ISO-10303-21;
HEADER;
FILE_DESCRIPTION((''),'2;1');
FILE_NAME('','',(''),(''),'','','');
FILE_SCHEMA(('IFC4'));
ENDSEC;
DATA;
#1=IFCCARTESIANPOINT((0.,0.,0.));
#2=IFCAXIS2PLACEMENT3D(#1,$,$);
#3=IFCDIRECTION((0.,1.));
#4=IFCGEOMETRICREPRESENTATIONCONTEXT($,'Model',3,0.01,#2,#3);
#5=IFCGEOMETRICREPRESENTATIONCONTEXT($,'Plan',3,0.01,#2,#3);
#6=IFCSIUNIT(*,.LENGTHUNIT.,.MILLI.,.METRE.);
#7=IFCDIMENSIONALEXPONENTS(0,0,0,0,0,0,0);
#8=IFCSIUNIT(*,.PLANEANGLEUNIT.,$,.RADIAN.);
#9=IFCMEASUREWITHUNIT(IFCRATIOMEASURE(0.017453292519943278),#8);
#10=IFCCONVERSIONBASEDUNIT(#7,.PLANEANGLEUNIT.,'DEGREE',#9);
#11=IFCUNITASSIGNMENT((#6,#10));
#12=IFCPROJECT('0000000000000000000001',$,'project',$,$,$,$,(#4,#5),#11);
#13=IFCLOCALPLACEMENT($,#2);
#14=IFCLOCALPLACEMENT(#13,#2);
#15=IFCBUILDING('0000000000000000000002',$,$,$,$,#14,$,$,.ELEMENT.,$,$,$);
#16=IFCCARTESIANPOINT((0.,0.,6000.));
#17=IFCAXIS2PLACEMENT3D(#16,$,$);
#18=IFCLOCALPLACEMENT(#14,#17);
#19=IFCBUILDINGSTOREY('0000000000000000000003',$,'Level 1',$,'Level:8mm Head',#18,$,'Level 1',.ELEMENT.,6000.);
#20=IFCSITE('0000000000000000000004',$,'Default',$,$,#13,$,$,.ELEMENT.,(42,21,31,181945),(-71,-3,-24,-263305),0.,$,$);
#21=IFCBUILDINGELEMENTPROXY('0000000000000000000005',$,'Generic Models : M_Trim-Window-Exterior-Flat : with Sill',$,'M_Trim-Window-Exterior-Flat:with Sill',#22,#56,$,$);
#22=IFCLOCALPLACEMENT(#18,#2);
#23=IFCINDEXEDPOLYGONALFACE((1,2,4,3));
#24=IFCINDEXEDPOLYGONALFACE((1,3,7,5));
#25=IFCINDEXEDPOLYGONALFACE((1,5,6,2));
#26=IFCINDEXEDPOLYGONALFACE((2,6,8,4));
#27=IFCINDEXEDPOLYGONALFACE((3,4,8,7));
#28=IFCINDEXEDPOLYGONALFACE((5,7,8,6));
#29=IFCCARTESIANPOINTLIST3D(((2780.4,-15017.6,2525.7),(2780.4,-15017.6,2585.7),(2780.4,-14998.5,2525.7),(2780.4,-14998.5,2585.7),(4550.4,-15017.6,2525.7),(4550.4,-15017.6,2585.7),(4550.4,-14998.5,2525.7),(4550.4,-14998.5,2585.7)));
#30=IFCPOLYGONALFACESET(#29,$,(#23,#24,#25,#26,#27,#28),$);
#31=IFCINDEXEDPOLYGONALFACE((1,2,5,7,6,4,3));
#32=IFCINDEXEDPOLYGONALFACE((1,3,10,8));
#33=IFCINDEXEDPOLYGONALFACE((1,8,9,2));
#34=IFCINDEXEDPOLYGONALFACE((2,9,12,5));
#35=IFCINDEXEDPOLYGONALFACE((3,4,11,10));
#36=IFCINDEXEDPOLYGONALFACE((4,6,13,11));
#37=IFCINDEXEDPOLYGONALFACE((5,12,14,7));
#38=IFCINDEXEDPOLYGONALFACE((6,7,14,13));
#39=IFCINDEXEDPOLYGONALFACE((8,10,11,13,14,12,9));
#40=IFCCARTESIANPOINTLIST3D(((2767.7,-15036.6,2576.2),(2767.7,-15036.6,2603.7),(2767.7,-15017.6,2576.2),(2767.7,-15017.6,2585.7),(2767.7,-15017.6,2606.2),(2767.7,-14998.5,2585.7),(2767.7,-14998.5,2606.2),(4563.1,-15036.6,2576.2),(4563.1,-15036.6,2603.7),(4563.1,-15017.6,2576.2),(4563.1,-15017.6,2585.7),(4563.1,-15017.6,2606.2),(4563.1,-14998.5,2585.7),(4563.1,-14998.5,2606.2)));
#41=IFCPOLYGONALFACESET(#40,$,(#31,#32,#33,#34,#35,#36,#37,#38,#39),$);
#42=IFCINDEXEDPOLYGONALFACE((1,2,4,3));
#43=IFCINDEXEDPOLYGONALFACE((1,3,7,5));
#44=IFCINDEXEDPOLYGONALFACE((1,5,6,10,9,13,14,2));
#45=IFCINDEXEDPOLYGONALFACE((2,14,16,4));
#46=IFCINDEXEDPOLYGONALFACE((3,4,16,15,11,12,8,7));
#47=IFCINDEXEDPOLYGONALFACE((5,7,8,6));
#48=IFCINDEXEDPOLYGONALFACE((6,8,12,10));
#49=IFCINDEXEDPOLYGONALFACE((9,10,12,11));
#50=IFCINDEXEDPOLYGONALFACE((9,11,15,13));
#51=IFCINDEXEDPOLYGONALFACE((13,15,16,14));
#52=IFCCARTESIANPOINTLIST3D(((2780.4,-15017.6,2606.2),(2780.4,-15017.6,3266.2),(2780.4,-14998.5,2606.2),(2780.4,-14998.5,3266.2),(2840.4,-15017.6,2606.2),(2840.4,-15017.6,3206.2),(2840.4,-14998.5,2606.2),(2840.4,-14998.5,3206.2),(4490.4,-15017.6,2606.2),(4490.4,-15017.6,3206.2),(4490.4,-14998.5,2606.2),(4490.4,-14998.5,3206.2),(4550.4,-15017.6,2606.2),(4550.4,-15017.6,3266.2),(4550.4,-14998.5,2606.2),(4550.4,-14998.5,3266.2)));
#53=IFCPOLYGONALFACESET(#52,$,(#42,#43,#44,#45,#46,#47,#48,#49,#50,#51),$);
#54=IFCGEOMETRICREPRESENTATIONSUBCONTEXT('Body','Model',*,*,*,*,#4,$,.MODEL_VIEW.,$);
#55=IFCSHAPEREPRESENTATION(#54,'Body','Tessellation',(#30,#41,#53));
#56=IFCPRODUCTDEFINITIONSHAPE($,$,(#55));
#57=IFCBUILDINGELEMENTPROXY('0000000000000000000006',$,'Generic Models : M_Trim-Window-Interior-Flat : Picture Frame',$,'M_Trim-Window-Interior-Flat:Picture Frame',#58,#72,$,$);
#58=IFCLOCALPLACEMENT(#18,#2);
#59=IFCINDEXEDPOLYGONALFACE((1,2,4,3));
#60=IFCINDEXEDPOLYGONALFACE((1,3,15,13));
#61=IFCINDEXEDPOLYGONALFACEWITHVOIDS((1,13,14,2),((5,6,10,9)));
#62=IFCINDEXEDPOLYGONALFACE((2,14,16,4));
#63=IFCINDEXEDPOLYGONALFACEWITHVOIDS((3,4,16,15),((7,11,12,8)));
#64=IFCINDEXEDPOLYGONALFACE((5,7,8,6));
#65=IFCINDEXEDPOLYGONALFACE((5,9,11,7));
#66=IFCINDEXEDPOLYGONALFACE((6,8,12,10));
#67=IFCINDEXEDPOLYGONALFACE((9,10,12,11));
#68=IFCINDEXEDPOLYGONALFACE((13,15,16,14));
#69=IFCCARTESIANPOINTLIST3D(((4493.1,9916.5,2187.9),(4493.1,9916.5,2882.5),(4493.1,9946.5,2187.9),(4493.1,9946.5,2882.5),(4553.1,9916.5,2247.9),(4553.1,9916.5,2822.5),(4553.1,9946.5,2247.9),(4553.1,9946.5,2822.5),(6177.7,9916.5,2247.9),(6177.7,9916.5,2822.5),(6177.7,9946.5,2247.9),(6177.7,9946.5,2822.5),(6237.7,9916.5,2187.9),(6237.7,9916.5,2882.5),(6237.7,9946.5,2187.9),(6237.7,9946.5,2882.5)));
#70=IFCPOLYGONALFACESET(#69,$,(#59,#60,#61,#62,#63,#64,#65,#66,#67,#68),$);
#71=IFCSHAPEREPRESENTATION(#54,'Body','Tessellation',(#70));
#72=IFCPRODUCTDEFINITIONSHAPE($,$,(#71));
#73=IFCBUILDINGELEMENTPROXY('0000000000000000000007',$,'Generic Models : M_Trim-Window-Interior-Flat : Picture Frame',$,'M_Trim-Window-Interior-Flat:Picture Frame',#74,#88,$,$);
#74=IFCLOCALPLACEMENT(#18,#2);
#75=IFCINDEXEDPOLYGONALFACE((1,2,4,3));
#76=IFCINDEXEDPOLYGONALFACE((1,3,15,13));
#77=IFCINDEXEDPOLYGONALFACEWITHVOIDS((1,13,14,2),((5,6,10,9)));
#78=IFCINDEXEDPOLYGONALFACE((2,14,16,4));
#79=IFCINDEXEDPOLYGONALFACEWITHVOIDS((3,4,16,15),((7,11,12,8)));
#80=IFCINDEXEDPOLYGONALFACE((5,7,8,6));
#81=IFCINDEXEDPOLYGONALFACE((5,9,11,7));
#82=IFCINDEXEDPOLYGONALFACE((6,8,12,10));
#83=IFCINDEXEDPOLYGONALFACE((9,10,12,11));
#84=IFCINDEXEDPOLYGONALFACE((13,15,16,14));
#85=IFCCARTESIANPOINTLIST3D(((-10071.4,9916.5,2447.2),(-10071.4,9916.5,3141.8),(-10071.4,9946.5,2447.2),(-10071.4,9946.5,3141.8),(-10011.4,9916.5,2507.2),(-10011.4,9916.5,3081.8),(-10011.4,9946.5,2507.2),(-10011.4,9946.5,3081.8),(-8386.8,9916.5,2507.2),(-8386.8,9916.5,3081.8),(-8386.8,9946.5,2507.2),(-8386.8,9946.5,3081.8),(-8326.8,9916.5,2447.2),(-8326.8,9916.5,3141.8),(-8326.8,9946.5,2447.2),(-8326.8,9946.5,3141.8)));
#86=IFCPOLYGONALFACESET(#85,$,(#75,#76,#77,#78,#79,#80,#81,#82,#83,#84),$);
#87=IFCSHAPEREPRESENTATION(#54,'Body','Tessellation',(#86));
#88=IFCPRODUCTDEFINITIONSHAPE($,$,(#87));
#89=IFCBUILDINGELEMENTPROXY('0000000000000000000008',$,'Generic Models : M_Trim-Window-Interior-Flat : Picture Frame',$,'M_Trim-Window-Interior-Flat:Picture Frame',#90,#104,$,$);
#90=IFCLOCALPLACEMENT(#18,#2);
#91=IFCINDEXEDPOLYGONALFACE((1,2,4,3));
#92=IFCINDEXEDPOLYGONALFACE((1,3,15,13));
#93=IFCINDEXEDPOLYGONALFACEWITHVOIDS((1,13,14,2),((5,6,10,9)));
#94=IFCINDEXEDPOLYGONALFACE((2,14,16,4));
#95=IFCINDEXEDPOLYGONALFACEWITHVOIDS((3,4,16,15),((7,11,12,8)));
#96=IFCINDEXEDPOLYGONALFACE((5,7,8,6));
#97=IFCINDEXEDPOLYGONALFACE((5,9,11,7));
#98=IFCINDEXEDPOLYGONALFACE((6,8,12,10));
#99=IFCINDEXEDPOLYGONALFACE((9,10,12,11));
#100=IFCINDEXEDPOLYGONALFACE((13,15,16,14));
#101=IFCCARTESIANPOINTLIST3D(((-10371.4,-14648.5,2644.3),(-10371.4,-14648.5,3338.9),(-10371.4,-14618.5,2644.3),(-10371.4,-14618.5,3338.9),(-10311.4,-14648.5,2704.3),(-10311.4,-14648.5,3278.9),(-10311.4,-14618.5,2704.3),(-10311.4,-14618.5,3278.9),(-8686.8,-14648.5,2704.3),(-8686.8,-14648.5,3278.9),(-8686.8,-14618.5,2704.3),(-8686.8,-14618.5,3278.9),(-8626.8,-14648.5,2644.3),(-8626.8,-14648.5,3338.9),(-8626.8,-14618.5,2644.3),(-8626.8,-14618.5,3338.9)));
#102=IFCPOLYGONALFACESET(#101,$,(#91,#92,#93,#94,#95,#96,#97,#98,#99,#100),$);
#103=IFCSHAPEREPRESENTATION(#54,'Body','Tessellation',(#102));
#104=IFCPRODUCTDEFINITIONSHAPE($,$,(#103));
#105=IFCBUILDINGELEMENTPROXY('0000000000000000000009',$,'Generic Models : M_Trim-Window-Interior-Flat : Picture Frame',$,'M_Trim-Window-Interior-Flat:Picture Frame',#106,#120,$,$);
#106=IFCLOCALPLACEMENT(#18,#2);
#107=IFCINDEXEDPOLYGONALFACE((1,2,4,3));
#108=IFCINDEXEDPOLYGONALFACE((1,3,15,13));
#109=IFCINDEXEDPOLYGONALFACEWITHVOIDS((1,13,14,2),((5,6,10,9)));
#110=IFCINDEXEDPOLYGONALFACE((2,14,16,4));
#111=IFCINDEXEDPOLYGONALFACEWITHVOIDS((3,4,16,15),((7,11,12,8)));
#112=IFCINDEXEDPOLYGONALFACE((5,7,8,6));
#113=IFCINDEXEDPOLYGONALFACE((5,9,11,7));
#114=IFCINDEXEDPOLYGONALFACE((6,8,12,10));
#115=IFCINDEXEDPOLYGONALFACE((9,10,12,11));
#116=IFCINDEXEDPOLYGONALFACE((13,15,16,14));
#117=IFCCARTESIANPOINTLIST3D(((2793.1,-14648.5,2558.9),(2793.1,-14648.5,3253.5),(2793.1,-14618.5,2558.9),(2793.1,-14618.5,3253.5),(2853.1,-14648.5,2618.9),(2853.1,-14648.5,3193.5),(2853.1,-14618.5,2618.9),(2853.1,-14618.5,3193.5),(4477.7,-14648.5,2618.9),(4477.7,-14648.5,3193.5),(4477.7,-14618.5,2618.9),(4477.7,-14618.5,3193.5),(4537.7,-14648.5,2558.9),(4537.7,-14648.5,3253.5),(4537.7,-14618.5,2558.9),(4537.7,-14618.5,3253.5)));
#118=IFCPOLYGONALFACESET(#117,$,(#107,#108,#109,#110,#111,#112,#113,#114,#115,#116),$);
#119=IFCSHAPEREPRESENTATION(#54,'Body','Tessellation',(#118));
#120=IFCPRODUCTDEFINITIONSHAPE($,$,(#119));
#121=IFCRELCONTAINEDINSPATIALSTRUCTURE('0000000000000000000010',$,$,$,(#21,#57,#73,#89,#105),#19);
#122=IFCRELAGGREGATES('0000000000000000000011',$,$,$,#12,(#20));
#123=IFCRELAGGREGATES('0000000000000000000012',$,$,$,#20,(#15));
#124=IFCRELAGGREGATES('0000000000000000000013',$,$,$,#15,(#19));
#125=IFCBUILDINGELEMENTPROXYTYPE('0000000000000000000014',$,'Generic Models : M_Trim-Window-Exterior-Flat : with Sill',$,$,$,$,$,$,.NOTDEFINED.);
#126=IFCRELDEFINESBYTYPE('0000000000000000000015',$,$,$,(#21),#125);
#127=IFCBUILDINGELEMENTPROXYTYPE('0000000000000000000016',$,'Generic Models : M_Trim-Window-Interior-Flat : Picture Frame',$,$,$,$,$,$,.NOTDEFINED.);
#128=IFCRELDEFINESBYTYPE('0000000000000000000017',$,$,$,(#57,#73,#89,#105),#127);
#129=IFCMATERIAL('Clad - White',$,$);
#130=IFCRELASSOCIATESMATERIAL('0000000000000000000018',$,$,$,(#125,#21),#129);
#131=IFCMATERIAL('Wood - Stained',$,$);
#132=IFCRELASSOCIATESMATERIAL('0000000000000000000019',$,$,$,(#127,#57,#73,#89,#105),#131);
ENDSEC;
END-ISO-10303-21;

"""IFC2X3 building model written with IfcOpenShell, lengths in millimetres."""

from ifc_helpers import new_model, entity, si_unit, converted_unit, direction, frame, frame_2d, origin, place, context, subcontext, project, spatial, polyline, rectangle, outline, extrude, source, transform, mapped, material, type_object, type_shapes, element, save


model = new_model("IFC2X3")

# Units and contexts
model_context = context("Model", 3, precision=0.01, world=origin(), true_north=direction((0.0, 1.0)))
plan_context = context("Plan", 3, precision=0.01, world=origin(), true_north=direction((0.0, 1.0)))
body_context = subcontext(model_context, "Body", "Model", "MODEL_VIEW")
ifc_project = project(units=[si_unit("LENGTHUNIT", "METRE", prefix="MILLI"), converted_unit("PLANEANGLEUNIT", "DEGREE", entity("IfcRatioMeasure", 0.017453292519943278), si_unit("PLANEANGLEUNIT", "RADIAN"), dimensions=[0, 0, 0, 0, 0, 0, 0])], contexts=[model_context, plan_context])

# Site, building, storey
site_placement = place(None, origin())
site = spatial("IfcSite", under=ifc_project, at=site_placement, Name="Default", CompositionType="ELEMENT", RefLatitude=(42, 21, 31, 181945), RefLongitude=(-71, -3, -24, -263305), RefElevation=0.0)
building_placement = place(site_placement, origin())
building = spatial("IfcBuilding", under=site, at=building_placement, CompositionType="ELEMENT")
storey_placement = place(building_placement, frame((0.0, 0.0, 6000.0)))
storey = spatial("IfcBuildingStorey", under=building, at=storey_placement, Name="Level 1", ObjectType="Level:8mm Head", LongName="Level 1", CompositionType="ELEMENT", Elevation=6000.0)

# Building element proxies
ifc_material_1 = material(Name="Clad - White")
building_element_proxy_type_1 = type_object("IfcBuildingElementProxyType", Name="Generic Models : M_Trim-Window-Exterior-Flat : with Sill", PredefinedType="NOTDEFINED", material=ifc_material_1)
shared_shape_1 = source(origin(), body_context, "Body", "SweptSolid", [
    extrude(rectangle(XDim=1770.0, YDim=60.0, at=frame_2d((0.0, 0.0), x_axis=(1.0, 0.0))), frame((0.0, -650.4, 0.0), z_axis=(0.0, 0.0, 1.0), x_axis=(-1.0, 0.0, 0.0)), (0.0, 0.0, 1.0), 19.0),
    extrude(outline(polyline([(-19.0, -15.2), (0.0, -15.2), (0.0, -5.7), (19.0, -5.7), (19.0, 14.8), (0.0, 14.8), (-19.0, 12.3), (-19.0, -15.2)])), frame((-897.7, -614.8, 19.0), z_axis=(1.0, 0.0, 0.0), x_axis=(0.0, 0.0, -1.0)), (0.0, 0.0, 1.0), 1795.4),
    extrude(outline(polyline([(-345.0, -885.0), (315.0, -885.0), (315.0, -825.0), (-285.0, -825.0), (-285.0, 825.0), (315.0, 825.0), (315.0, 885.0), (-345.0, 885.0), (-345.0, -885.0)])), frame((0.0, -285.0, 0.0), z_axis=(0.0, 0.0, 1.0), x_axis=(0.0, -1.0, 0.0)), (0.0, 0.0, 1.0), 19.0),
])
type_shapes(building_element_proxy_type_1, [shared_shape_1])
for number, where, z_axis, x_axis, name in (
    (1, (3665.4, -14998.5, 3206.2), (0.0, -1.0, 0.0), (1.0, 0.0, 0.0), "Generic Models : M_Trim-Window-Exterior-Flat : with Sill"),
):
    element("IfcBuildingElementProxy", number, at=place(storey_placement, frame(where, z_axis=z_axis, x_axis=x_axis)), inside=storey, type_object=building_element_proxy_type_1, material=ifc_material_1, Name=name, ObjectType="M_Trim-Window-Exterior-Flat:with Sill", context=body_context, shape_type="MappedRepresentation", body=[
        mapped(shared_shape_1, transform((0.0, 0.0, 0.0), scale=1.0)),
    ])
ifc_material_2 = material(Name="Wood - Stained")
building_element_proxy_type_2 = type_object("IfcBuildingElementProxyType", Name="Generic Models : M_Trim-Window-Interior-Flat : Picture Frame", PredefinedType="NOTDEFINED", material=ifc_material_2)
shared_shape_2 = source(origin(), body_context, "Body", "SweptSolid", [
    extrude(outline(polyline([(-872.3, -347.3), (872.3, -347.3), (872.3, 347.3), (-872.3, 347.3), (-872.3, -347.3)]), holes=[polyline([(-812.3, -287.3), (-812.3, 287.3), (812.3, 287.3), (812.3, -287.3), (-812.3, -287.3)])]), frame((0.0, -300.0, 0.0), z_axis=(0.0, 0.0, 1.0), x_axis=(-1.0, 0.0, 0.0)), (0.0, 0.0, 1.0), 30.0),
])
type_shapes(building_element_proxy_type_2, [shared_shape_2])
for number, where, z_axis, x_axis, name in (
    (2, (5365.4, 9946.5, 2835.2), (0.0, -1.0, 0.0), (1.0, 0.0, 0.0), "Generic Models : M_Trim-Window-Interior-Flat : Picture Frame"),
    (3, (-9199.1, 9946.5, 3094.5), (0.0, -1.0, 0.0), (1.0, 0.0, 0.0), "Generic Models : M_Trim-Window-Interior-Flat : Picture Frame"),
    (4, (-9499.1, -14648.5, 3291.6), (0.0, 1.0, 0.0), (-1.0, 0.0, 0.0), "Generic Models : M_Trim-Window-Interior-Flat : Picture Frame"),
    (5, (3665.4, -14648.5, 3206.2), (0.0, 1.0, 0.0), (-1.0, 0.0, 0.0), "Generic Models : M_Trim-Window-Interior-Flat : Picture Frame"),
):
    element("IfcBuildingElementProxy", number, at=place(storey_placement, frame(where, z_axis=z_axis, x_axis=x_axis)), inside=storey, type_object=building_element_proxy_type_2, material=ifc_material_2, Name=name, ObjectType="M_Trim-Window-Interior-Flat:Picture Frame", context=body_context, shape_type="MappedRepresentation", body=[
        mapped(shared_shape_2, transform((0.0, 0.0, 0.0), scale=1.0)),
    ])

save(model, "model.ifc")
